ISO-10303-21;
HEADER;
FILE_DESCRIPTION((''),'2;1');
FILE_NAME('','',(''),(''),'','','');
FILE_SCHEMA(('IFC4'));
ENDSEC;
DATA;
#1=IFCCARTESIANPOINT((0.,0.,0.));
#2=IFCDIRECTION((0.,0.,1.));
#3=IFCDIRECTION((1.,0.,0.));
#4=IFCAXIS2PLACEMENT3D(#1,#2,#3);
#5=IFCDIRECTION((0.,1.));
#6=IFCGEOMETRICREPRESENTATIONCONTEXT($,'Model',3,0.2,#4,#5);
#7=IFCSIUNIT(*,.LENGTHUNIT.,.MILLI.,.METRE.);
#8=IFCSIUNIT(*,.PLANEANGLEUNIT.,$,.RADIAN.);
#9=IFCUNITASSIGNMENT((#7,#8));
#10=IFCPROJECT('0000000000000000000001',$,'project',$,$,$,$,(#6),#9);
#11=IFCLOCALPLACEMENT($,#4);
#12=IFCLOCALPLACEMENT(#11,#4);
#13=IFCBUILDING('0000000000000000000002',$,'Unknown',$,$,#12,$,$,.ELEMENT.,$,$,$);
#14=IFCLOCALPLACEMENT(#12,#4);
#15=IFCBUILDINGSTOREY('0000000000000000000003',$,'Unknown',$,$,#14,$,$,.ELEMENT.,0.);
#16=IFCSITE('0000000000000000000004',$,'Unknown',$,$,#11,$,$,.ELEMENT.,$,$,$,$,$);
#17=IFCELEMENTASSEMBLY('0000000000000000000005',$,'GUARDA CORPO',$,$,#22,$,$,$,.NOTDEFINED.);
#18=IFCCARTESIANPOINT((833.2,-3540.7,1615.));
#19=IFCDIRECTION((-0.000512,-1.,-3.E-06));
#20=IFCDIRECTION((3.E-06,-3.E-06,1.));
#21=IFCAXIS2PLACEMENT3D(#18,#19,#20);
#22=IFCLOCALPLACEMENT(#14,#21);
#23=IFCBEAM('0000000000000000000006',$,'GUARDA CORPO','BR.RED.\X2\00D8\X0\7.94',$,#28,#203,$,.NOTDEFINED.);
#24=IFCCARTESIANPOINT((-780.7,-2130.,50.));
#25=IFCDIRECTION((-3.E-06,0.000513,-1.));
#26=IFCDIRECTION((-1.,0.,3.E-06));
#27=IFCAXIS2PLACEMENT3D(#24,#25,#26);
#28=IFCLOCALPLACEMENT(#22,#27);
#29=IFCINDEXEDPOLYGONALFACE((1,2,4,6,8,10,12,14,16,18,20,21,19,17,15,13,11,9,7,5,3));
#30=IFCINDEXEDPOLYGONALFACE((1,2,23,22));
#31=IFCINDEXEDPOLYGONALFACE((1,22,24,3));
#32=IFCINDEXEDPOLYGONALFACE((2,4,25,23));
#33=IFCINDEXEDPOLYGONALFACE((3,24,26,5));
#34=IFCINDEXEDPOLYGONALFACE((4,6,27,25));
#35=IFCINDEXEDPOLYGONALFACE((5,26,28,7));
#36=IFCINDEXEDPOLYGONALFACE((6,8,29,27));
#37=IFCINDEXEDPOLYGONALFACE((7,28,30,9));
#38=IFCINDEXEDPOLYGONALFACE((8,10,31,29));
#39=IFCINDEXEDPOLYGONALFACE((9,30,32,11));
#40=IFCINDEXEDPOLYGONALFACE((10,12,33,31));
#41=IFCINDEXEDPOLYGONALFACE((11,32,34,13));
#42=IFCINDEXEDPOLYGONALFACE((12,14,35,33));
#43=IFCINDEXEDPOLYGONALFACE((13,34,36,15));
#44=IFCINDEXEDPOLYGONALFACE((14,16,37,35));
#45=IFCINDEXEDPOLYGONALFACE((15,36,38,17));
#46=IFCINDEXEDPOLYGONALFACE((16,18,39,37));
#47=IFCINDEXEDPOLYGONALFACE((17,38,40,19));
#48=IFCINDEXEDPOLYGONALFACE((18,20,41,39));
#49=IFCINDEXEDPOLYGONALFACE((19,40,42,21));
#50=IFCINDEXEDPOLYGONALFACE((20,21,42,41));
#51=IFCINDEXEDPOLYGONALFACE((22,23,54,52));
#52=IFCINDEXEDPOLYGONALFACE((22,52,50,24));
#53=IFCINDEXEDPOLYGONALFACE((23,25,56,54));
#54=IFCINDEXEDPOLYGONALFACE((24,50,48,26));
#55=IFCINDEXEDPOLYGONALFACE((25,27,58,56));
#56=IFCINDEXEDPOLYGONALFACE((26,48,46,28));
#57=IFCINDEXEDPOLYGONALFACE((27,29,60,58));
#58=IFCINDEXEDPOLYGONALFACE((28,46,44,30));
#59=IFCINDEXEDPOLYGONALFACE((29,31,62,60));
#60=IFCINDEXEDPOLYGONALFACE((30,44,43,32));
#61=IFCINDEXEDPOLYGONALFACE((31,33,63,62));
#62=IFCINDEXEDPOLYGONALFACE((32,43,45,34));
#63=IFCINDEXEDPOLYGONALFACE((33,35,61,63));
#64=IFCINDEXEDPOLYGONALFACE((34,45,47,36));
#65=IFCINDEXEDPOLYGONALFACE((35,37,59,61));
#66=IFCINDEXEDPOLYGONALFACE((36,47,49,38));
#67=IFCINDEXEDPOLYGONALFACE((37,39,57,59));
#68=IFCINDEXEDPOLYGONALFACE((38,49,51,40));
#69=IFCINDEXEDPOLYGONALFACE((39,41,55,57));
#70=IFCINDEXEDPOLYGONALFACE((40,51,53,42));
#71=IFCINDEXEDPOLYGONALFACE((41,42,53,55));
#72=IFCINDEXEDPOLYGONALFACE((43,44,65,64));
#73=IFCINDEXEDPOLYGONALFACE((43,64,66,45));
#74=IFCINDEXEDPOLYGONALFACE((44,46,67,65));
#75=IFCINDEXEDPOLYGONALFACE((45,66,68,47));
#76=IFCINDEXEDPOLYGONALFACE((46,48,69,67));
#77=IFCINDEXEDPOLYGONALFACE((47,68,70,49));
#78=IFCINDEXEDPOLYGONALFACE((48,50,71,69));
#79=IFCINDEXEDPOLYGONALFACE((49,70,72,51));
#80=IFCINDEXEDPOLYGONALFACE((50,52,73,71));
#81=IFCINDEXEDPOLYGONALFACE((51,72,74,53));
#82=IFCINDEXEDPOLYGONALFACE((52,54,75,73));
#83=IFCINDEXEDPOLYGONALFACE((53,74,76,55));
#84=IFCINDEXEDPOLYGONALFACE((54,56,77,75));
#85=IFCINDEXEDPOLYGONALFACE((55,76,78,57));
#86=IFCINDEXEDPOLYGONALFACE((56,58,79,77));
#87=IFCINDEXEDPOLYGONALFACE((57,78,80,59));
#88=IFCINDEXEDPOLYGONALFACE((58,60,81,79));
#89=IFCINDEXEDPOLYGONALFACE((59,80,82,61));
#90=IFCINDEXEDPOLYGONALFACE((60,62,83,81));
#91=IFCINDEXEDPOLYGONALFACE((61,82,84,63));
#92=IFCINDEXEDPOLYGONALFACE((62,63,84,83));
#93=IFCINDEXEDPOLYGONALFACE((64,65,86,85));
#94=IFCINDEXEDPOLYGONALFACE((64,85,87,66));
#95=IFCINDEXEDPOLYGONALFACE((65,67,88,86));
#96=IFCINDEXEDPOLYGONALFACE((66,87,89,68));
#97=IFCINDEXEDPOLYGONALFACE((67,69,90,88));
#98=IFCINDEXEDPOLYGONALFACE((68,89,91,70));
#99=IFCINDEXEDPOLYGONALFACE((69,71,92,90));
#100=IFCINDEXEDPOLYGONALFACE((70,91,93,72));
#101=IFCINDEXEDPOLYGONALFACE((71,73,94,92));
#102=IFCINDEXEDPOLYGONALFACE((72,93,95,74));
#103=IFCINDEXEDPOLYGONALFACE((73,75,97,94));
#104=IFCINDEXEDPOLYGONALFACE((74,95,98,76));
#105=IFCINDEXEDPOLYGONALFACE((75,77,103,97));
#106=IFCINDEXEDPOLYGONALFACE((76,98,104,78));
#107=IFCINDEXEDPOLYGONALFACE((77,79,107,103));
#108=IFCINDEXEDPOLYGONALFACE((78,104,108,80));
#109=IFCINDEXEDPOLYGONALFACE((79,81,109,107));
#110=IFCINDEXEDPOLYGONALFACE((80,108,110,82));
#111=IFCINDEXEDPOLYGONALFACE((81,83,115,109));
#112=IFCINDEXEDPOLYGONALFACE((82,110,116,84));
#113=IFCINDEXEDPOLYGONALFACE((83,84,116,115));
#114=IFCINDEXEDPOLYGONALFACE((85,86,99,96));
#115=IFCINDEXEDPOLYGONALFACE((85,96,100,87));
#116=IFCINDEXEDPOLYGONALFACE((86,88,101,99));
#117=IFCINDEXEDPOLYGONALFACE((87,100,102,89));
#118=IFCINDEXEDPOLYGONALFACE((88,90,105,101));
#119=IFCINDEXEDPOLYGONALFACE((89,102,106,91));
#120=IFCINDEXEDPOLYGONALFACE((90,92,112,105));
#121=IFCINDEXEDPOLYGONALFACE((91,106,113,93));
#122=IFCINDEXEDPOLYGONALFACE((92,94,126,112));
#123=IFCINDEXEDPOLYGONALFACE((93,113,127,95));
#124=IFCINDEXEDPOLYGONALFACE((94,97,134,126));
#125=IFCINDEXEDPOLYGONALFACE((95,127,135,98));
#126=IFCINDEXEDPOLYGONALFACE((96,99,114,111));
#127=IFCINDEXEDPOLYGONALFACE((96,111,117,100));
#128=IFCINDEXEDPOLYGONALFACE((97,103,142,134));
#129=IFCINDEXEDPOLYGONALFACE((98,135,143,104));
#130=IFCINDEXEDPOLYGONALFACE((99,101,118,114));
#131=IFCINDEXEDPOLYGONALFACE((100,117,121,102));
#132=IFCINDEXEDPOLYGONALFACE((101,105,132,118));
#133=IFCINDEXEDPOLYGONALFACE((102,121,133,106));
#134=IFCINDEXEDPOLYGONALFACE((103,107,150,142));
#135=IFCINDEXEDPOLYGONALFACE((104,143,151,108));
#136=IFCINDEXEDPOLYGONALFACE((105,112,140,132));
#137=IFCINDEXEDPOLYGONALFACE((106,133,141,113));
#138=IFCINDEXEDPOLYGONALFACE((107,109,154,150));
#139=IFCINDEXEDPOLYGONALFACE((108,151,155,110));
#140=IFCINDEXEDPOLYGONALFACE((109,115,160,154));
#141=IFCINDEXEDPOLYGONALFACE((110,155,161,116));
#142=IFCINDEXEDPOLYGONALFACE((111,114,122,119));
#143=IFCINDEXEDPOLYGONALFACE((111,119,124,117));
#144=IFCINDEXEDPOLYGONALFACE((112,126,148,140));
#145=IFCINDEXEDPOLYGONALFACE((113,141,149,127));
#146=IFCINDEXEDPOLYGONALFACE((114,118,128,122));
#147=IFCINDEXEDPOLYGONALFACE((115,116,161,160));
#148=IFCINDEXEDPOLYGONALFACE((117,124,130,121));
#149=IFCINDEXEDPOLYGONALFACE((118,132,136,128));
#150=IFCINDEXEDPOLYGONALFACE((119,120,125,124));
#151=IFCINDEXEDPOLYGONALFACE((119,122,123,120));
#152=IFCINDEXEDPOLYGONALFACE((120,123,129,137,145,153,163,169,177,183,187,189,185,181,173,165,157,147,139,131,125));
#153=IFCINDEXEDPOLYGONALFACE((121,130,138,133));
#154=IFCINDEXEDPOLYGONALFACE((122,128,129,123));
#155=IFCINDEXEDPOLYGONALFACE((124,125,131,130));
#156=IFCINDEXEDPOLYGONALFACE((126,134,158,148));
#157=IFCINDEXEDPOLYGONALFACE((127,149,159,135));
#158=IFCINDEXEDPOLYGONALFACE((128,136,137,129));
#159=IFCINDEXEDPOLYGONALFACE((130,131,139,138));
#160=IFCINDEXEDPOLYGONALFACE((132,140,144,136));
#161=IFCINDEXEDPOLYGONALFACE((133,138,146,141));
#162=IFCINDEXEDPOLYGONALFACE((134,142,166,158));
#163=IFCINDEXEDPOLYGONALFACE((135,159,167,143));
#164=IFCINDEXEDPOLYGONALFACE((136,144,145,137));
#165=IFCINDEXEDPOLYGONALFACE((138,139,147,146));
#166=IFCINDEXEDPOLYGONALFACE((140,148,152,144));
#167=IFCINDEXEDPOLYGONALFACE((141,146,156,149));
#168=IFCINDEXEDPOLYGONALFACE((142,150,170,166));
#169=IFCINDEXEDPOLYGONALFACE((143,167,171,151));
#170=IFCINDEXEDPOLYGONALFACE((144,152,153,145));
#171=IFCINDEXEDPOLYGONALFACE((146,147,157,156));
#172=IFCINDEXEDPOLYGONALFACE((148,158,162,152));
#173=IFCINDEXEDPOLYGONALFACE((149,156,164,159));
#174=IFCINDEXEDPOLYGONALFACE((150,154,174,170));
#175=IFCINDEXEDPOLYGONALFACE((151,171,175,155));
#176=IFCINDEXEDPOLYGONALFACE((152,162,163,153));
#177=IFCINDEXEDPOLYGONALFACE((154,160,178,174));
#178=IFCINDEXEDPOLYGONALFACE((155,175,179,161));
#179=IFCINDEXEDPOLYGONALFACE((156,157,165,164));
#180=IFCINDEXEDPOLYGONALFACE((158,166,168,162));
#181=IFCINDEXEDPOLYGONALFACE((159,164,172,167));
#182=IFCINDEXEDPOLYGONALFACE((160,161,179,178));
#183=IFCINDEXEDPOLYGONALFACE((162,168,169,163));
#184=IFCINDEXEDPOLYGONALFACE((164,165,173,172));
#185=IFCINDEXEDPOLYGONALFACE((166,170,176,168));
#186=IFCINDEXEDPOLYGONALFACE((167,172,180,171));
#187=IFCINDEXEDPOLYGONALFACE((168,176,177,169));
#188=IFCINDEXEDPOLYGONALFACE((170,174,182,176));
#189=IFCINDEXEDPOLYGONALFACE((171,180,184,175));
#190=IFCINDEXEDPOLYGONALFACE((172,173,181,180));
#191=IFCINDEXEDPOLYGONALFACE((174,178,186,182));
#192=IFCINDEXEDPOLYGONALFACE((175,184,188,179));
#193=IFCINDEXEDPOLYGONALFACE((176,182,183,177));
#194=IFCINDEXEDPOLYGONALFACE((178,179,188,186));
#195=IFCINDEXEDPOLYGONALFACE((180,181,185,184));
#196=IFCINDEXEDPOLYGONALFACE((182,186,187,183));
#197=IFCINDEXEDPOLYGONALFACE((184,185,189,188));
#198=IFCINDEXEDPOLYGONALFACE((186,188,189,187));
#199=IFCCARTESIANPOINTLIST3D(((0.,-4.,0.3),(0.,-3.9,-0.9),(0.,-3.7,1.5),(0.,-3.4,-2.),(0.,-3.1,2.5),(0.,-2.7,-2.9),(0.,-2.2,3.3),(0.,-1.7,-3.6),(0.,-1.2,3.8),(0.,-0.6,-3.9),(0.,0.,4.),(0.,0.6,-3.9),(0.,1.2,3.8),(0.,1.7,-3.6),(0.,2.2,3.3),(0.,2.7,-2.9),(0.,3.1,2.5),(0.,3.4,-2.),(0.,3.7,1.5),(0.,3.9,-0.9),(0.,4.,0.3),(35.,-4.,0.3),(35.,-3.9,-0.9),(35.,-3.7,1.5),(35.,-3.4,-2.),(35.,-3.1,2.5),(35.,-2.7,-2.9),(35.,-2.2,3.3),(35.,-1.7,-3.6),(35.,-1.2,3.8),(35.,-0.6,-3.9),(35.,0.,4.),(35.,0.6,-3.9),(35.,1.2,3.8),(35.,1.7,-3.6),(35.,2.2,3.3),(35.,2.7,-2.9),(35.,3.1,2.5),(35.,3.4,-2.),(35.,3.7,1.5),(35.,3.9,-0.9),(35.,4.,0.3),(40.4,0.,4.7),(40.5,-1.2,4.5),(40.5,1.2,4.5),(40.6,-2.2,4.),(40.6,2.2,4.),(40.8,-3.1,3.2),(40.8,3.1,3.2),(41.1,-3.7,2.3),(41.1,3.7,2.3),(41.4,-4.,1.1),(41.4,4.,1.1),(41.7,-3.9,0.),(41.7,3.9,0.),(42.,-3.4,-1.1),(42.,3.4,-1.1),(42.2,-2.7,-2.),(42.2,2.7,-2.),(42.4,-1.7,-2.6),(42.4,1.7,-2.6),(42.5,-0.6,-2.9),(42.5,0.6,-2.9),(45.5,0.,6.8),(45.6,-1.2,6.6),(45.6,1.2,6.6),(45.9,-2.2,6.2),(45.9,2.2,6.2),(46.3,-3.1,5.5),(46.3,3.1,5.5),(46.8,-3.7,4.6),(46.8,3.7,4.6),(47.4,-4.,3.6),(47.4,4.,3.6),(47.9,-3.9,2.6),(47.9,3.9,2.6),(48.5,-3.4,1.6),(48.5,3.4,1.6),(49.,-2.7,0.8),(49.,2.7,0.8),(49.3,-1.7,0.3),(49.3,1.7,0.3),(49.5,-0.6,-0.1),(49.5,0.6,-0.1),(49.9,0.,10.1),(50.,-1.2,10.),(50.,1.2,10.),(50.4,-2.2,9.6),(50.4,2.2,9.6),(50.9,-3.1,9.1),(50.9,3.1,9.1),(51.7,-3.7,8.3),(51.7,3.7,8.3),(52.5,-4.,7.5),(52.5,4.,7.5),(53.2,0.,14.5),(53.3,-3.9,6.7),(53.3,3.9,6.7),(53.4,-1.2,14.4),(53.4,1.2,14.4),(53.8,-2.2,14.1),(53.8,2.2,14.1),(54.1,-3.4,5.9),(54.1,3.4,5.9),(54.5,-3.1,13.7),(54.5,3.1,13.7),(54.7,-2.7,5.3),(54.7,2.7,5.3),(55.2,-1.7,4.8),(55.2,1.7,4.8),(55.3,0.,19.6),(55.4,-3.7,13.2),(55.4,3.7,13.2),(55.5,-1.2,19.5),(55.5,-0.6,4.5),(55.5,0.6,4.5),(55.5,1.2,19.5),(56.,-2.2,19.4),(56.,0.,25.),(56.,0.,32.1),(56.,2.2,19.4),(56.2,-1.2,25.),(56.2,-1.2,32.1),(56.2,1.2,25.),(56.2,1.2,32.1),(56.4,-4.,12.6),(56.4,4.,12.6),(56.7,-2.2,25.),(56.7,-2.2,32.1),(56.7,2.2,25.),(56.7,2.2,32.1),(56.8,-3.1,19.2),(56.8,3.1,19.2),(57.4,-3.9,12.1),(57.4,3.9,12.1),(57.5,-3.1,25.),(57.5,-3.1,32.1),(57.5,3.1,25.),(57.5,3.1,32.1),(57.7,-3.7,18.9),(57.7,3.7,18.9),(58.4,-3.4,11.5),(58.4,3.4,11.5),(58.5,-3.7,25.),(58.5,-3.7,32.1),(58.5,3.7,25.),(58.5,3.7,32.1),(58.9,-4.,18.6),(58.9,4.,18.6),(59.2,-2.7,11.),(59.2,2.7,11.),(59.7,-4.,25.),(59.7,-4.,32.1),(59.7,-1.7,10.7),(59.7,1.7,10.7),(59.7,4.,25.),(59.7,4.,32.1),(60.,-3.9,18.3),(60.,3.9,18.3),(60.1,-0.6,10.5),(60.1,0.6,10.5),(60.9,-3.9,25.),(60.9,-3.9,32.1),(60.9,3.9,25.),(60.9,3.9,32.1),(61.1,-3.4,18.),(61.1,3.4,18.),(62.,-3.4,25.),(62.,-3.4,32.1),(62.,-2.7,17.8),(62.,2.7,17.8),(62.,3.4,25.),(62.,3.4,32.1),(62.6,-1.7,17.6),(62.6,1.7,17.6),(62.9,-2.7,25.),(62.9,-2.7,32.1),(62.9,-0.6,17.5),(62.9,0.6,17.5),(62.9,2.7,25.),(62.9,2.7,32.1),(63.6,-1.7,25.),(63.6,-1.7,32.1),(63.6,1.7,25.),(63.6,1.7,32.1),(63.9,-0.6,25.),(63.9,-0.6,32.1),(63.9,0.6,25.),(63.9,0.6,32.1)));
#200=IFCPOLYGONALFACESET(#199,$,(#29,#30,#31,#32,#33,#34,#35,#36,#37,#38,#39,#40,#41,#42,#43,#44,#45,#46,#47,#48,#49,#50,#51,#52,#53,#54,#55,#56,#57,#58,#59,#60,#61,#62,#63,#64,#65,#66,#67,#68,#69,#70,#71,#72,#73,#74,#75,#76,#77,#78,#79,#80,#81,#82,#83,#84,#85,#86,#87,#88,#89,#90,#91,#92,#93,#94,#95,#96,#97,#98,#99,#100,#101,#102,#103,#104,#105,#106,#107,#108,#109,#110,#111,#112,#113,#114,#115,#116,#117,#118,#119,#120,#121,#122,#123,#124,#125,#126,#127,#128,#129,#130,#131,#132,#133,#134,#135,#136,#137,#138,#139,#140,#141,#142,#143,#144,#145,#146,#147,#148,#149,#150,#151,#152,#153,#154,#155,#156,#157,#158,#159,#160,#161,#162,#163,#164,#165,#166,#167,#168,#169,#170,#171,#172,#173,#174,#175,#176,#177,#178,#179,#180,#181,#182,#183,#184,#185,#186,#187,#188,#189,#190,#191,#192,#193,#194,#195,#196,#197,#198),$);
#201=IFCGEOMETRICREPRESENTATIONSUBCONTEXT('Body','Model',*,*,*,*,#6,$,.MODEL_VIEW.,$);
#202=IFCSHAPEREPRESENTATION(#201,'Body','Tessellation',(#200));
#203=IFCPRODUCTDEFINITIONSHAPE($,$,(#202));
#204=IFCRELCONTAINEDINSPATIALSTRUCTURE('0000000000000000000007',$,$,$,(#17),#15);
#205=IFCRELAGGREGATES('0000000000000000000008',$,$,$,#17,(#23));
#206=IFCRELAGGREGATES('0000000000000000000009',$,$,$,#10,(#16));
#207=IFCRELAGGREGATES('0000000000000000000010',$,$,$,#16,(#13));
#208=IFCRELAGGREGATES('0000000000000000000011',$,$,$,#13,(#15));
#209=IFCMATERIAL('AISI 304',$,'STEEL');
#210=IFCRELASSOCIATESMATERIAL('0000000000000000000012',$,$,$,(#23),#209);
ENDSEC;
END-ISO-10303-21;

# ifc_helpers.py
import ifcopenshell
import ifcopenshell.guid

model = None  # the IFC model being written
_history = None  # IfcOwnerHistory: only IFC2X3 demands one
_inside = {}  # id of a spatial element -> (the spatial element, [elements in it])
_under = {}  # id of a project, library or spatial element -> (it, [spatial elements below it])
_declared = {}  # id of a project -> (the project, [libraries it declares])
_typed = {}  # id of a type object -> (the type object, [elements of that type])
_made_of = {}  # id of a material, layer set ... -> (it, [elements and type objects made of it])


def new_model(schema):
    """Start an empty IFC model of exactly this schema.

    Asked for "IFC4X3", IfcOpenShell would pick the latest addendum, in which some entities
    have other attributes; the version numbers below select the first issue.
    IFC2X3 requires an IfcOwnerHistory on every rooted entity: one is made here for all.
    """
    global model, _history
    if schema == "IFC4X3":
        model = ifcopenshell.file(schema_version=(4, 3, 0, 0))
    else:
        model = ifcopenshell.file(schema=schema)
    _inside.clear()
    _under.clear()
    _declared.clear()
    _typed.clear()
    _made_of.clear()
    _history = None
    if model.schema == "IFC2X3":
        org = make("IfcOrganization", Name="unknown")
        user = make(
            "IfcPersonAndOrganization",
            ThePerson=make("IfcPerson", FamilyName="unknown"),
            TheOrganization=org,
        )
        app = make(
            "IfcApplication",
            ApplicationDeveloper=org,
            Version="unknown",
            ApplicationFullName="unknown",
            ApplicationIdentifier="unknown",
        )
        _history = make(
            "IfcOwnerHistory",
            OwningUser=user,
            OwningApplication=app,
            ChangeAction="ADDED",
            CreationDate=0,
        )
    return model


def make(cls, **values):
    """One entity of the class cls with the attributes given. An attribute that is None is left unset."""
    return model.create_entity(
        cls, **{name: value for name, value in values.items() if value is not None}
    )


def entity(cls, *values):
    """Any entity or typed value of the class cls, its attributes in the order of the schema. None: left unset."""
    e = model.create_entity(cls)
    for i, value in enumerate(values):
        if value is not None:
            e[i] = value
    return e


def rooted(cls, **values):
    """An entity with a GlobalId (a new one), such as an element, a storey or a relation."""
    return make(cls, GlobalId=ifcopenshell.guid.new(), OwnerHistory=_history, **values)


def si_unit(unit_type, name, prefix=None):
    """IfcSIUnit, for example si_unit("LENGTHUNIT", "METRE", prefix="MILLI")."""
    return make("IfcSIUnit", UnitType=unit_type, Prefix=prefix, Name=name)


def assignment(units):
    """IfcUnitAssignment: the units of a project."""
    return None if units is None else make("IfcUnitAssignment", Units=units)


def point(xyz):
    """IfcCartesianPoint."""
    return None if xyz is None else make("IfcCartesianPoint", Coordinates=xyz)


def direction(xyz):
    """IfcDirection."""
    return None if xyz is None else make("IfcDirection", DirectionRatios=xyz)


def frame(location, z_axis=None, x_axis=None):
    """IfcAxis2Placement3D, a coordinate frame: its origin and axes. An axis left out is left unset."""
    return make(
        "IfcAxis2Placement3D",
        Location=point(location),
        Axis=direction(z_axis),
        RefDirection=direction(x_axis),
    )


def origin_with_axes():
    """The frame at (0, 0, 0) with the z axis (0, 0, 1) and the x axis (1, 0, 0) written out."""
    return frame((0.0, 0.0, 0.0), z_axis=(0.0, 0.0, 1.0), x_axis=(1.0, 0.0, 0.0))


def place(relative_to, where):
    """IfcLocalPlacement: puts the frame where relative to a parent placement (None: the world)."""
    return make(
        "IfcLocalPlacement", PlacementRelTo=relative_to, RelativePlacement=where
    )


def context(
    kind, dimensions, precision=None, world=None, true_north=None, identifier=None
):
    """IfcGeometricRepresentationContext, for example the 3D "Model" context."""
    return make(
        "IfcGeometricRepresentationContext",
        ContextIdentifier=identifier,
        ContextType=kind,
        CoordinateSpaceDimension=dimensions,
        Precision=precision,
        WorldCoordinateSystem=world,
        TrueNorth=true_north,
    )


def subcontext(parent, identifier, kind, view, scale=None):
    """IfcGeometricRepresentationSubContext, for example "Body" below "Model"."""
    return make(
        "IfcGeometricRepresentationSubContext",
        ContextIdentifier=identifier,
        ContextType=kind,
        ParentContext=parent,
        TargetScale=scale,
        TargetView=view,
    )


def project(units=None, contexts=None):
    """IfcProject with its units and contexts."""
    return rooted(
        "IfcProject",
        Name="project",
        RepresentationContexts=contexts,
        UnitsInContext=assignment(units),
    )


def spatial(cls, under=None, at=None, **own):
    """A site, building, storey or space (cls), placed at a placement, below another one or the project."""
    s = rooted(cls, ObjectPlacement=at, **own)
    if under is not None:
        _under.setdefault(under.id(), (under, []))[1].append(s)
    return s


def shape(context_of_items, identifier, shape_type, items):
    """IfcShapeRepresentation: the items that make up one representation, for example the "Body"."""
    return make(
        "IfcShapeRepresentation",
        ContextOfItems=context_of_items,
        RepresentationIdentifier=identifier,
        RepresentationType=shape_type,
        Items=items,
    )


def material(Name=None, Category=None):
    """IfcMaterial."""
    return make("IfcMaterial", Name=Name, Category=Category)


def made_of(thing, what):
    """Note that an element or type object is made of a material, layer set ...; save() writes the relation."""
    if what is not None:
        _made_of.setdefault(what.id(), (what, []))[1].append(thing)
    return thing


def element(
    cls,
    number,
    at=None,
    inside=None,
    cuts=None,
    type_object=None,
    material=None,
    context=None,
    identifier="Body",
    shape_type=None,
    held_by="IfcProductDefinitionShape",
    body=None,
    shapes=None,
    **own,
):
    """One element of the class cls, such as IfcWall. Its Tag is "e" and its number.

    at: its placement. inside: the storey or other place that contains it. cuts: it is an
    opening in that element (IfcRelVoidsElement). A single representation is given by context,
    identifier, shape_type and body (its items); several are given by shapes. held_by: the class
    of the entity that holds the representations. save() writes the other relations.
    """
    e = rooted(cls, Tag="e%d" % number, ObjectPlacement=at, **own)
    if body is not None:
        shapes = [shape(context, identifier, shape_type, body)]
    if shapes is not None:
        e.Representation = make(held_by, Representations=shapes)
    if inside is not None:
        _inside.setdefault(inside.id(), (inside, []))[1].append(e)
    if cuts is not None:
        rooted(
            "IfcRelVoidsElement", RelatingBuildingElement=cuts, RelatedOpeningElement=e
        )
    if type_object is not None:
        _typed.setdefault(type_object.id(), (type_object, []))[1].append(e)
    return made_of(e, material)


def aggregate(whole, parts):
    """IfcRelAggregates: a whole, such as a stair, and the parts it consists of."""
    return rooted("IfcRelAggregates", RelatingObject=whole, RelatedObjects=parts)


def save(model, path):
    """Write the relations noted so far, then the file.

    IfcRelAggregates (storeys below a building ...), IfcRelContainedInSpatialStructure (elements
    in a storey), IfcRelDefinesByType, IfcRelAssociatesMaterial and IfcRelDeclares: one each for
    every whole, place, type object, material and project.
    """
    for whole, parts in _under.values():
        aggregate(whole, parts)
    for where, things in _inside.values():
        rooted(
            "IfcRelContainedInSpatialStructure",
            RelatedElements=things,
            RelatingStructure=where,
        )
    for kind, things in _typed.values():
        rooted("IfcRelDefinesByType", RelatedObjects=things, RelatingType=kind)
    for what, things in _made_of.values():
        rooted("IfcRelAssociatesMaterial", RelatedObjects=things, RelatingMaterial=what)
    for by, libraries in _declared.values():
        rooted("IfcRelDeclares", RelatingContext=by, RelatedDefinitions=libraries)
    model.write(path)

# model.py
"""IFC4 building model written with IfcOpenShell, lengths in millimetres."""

from ifc_helpers import new_model, entity, si_unit, direction, frame, origin_with_axes, place, context, subcontext, project, spatial, material, element, aggregate, save


model = new_model("IFC4")

# Units and contexts
model_context = context("Model", 3, precision=0.2, world=origin_with_axes(), true_north=direction((0.0, 1.0)))
body_context = subcontext(model_context, "Body", "Model", "MODEL_VIEW")
ifc_project = project(units=[si_unit("LENGTHUNIT", "METRE", prefix="MILLI"), si_unit("PLANEANGLEUNIT", "RADIAN")], contexts=[model_context])

# Site, building, storey
site_placement = place(None, origin_with_axes())
site = spatial("IfcSite", under=ifc_project, at=site_placement, Name="Unknown", CompositionType="ELEMENT")
building_placement = place(site_placement, origin_with_axes())
building = spatial("IfcBuilding", under=site, at=building_placement, Name="Unknown", CompositionType="ELEMENT")
storey_placement = place(building_placement, origin_with_axes())
storey = spatial("IfcBuildingStorey", under=building, at=storey_placement, Name="Unknown", CompositionType="ELEMENT", Elevation=0.0)

# Shared definitions
ifc_material_1 = material(Name="AISI 304", Category="STEEL")

# Element assembly, beam
assembly_1_placement = place(storey_placement, frame((833.2, -3540.7, 1615.0), z_axis=(-0.000512, -1.0, -0.000003), x_axis=(0.000003, -0.000003, 1.0)))
assembly_1 = element("IfcElementAssembly", 1, at=assembly_1_placement, inside=storey, Name="GUARDA CORPO", PredefinedType="NOTDEFINED")
beam_1_placement = place(assembly_1_placement, frame((-780.7, -2130.0, 50.0), z_axis=(-0.000003, 0.000513, -1.0), x_axis=(-1.0, 0.0, 0.000003)))
beam_1 = element("IfcBeam", 2, at=beam_1_placement, material=ifc_material_1, Name="GUARDA CORPO", Description="BR.RED.Ø7.94", PredefinedType="NOTDEFINED", context=body_context, shape_type="SolidModel", body=[
    entity("IfcSweptDiskSolid", entity("IfcIndexedPolyCurve", entity("IfcCartesianPointList3D", [[0.0, 0.0, 0.0], [35.0, 0.0, 0.0], [52.7, 0.0, 7.3], [60.0, 0.0, 25.0], [60.0, 0.0, 32.1]]), [entity("IfcLineIndex", [1, 2]), entity("IfcArcIndex", [2, 3, 4]), entity("IfcLineIndex", [4, 5])]), 4.0),
])

aggregate(assembly_1, [beam_1])

save(model, "model.ifc")
